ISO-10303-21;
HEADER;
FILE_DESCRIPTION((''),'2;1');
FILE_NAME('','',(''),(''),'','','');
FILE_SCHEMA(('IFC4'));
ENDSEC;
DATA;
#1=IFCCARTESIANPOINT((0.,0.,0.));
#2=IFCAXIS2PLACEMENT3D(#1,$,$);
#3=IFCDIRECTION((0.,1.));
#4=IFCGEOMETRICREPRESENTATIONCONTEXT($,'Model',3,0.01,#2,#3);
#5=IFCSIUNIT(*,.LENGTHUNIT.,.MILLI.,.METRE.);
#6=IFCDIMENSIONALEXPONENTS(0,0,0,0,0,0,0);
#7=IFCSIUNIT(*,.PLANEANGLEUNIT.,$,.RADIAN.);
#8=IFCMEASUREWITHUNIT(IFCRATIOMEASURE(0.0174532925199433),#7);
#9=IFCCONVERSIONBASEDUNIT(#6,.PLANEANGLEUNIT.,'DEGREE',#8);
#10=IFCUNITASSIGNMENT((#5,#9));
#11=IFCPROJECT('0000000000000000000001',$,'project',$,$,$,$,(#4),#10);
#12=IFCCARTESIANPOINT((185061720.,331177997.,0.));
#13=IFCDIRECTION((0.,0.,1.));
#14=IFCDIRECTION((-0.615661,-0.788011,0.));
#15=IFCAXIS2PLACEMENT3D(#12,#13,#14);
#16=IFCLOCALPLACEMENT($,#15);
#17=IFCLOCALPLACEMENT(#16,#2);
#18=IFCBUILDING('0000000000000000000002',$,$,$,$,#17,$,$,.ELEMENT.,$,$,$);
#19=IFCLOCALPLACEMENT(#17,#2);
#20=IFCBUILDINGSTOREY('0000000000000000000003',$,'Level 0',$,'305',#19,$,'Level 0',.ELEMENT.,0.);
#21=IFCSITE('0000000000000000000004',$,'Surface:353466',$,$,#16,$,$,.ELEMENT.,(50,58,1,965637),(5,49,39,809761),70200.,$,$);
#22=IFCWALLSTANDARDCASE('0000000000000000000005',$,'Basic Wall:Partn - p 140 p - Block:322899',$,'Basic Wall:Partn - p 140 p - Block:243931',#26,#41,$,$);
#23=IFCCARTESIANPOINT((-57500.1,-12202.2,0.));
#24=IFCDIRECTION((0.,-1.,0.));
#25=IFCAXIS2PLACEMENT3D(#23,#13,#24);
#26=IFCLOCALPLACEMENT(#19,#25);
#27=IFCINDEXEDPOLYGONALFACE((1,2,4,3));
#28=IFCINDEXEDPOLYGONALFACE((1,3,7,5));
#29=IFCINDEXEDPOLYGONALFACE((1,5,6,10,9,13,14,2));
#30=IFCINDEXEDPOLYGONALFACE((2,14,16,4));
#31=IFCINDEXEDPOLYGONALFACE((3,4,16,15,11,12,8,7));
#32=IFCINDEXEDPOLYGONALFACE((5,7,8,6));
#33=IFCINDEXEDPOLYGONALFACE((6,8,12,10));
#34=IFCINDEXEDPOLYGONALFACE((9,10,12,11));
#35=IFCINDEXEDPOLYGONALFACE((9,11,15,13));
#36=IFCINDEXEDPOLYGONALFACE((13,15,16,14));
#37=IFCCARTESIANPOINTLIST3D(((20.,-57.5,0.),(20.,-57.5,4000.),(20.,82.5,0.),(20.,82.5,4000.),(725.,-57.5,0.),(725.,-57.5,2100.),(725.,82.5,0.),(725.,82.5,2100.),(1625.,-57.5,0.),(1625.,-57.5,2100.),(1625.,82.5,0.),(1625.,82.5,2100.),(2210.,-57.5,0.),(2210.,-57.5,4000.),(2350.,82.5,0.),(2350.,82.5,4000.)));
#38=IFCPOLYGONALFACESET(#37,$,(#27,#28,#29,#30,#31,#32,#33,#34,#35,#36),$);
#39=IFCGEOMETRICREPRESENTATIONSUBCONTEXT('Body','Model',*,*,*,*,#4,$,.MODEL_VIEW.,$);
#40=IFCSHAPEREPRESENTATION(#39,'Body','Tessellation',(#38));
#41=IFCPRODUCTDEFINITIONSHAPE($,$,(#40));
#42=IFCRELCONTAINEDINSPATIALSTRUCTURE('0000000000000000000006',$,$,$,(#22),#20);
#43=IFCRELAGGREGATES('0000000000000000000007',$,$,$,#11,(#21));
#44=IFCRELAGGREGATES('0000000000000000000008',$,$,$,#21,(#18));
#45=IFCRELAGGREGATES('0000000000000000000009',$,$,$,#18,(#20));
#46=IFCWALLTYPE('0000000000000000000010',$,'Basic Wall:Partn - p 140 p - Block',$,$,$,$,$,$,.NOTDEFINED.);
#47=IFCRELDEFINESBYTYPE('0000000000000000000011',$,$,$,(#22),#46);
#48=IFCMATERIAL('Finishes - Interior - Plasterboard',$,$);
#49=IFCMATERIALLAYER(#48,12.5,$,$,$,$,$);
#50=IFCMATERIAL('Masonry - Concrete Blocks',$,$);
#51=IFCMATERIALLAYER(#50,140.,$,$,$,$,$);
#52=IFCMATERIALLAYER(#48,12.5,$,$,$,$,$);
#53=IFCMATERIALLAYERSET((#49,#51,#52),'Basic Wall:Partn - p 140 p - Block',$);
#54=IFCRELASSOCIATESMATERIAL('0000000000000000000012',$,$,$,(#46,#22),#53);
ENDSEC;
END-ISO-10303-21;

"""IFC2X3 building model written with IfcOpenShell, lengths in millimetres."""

from ifc_helpers import new_model, entity, si_unit, converted_unit, direction, frame, frame_2d, origin, origin_2d_with_axis, place, context, subcontext, project, spatial, polyline, rectangle, outline, extrude, clip, halfspace, material, layer, layer_set, layer_usage, type_object, element, save


model = new_model("IFC2X3")

# Units and contexts
model_context = context("Model", 3, precision=0.01, world=origin(), true_north=direction((0.0, 1.0)))
body_context = subcontext(model_context, "Body", "Model", "MODEL_VIEW")
ifc_project = project(units=[si_unit("LENGTHUNIT", "METRE", prefix="MILLI"), converted_unit("PLANEANGLEUNIT", "DEGREE", entity("IfcRatioMeasure", 0.0174532925199433), si_unit("PLANEANGLEUNIT", "RADIAN"), dimensions=[0, 0, 0, 0, 0, 0, 0])], contexts=[model_context])

# Site, building, storey
site_placement = place(None, frame((185061720.0, 331177997.0, 0.0), z_axis=(0.0, 0.0, 1.0), x_axis=(-0.615661, -0.788011, 0.0)))
site = spatial("IfcSite", under=ifc_project, at=site_placement, Name="Surface:353466", CompositionType="ELEMENT", RefLatitude=(50, 58, 1, 965637), RefLongitude=(5, 49, 39, 809761), RefElevation=70200.0)
building_placement = place(site_placement, origin())
building = spatial("IfcBuilding", under=site, at=building_placement, CompositionType="ELEMENT")
storey_placement = place(building_placement, origin())
storey = spatial("IfcBuildingStorey", under=building, at=storey_placement, Name="Level 0", ObjectType="305", LongName="Level 0", CompositionType="ELEMENT", Elevation=0.0)

# Shared definitions
ifc_material_1 = material(Name="Masonry - Concrete Blocks")
ifc_material_2 = material(Name="Finishes - Interior - Plasterboard")

# Wall, openings
ifc_layer_1 = layer(ifc_material_2, 12.5)
ifc_layer_2 = layer(ifc_material_1, 140.0)
ifc_layer_3 = layer(ifc_material_2, 12.5)
ifc_layer_set_1 = layer_set([ifc_layer_1, ifc_layer_2, ifc_layer_3], Name="Basic Wall:Partn - p 140 p - Block")
ifc_layer_usage_1 = layer_usage(ifc_layer_set_1, "AXIS2", "POSITIVE", -82.5)
wall_type_1 = type_object("IfcWallType", Name="Basic Wall:Partn - p 140 p - Block", PredefinedType="NOTDEFINED", material=ifc_layer_set_1)
wall_1_placement = place(storey_placement, frame((-57500.1, -12202.2, 0.0), z_axis=(0.0, 0.0, 1.0), x_axis=(0.0, -1.0, 0.0)))
wall_1 = element("IfcWallStandardCase", 1, at=wall_1_placement, inside=storey, type_object=wall_type_1, material=ifc_layer_usage_1, Name="Basic Wall:Partn - p 140 p - Block:322899", ObjectType="Basic Wall:Partn - p 140 p - Block:243931", context=body_context, shape_type="Clipping", body=[
    clip(extrude(outline(polyline([(2210.0, -57.5), (2350.0, 82.5), (20.0, 82.5), (20.0, -57.5), (2210.0, -57.5)])), origin(), (0.0, 0.0, 1.0), 4000.0), halfspace(origin(), True)),
])
opening_1_placement = place(wall_1_placement, origin())
element("IfcOpeningElement", 2, at=opening_1_placement, cuts=wall_1, ObjectType="Opening", context=body_context, shape_type="SweptSolid", body=[
    extrude(rectangle(XDim=2100.0, YDim=900.0, at=origin_2d_with_axis()), frame((1175.0, -1606.5, 1050.0), z_axis=(0.0, 1.0, 0.0), x_axis=(0.0, 0.0, 1.0)), (0.0, 0.0, 1.0), 3048.0),
])
opening_2_placement = place(wall_1_placement, origin())
element("IfcOpeningElement", 3, at=opening_2_placement, cuts=wall_1, ObjectType="Opening", context=body_context, shape_type="SweptSolid", body=[
    extrude(rectangle(XDim=2100.0, YDim=900.0, at=frame_2d((0.0, 0.0), x_axis=(1.0, 0.0))), frame((1175.0, -1606.5, 5050.0), z_axis=(0.0, 1.0, 0.0), x_axis=(0.0, 0.0, 1.0)), (0.0, 0.0, 1.0), 3048.0),
])

save(model, "model.ifc")
